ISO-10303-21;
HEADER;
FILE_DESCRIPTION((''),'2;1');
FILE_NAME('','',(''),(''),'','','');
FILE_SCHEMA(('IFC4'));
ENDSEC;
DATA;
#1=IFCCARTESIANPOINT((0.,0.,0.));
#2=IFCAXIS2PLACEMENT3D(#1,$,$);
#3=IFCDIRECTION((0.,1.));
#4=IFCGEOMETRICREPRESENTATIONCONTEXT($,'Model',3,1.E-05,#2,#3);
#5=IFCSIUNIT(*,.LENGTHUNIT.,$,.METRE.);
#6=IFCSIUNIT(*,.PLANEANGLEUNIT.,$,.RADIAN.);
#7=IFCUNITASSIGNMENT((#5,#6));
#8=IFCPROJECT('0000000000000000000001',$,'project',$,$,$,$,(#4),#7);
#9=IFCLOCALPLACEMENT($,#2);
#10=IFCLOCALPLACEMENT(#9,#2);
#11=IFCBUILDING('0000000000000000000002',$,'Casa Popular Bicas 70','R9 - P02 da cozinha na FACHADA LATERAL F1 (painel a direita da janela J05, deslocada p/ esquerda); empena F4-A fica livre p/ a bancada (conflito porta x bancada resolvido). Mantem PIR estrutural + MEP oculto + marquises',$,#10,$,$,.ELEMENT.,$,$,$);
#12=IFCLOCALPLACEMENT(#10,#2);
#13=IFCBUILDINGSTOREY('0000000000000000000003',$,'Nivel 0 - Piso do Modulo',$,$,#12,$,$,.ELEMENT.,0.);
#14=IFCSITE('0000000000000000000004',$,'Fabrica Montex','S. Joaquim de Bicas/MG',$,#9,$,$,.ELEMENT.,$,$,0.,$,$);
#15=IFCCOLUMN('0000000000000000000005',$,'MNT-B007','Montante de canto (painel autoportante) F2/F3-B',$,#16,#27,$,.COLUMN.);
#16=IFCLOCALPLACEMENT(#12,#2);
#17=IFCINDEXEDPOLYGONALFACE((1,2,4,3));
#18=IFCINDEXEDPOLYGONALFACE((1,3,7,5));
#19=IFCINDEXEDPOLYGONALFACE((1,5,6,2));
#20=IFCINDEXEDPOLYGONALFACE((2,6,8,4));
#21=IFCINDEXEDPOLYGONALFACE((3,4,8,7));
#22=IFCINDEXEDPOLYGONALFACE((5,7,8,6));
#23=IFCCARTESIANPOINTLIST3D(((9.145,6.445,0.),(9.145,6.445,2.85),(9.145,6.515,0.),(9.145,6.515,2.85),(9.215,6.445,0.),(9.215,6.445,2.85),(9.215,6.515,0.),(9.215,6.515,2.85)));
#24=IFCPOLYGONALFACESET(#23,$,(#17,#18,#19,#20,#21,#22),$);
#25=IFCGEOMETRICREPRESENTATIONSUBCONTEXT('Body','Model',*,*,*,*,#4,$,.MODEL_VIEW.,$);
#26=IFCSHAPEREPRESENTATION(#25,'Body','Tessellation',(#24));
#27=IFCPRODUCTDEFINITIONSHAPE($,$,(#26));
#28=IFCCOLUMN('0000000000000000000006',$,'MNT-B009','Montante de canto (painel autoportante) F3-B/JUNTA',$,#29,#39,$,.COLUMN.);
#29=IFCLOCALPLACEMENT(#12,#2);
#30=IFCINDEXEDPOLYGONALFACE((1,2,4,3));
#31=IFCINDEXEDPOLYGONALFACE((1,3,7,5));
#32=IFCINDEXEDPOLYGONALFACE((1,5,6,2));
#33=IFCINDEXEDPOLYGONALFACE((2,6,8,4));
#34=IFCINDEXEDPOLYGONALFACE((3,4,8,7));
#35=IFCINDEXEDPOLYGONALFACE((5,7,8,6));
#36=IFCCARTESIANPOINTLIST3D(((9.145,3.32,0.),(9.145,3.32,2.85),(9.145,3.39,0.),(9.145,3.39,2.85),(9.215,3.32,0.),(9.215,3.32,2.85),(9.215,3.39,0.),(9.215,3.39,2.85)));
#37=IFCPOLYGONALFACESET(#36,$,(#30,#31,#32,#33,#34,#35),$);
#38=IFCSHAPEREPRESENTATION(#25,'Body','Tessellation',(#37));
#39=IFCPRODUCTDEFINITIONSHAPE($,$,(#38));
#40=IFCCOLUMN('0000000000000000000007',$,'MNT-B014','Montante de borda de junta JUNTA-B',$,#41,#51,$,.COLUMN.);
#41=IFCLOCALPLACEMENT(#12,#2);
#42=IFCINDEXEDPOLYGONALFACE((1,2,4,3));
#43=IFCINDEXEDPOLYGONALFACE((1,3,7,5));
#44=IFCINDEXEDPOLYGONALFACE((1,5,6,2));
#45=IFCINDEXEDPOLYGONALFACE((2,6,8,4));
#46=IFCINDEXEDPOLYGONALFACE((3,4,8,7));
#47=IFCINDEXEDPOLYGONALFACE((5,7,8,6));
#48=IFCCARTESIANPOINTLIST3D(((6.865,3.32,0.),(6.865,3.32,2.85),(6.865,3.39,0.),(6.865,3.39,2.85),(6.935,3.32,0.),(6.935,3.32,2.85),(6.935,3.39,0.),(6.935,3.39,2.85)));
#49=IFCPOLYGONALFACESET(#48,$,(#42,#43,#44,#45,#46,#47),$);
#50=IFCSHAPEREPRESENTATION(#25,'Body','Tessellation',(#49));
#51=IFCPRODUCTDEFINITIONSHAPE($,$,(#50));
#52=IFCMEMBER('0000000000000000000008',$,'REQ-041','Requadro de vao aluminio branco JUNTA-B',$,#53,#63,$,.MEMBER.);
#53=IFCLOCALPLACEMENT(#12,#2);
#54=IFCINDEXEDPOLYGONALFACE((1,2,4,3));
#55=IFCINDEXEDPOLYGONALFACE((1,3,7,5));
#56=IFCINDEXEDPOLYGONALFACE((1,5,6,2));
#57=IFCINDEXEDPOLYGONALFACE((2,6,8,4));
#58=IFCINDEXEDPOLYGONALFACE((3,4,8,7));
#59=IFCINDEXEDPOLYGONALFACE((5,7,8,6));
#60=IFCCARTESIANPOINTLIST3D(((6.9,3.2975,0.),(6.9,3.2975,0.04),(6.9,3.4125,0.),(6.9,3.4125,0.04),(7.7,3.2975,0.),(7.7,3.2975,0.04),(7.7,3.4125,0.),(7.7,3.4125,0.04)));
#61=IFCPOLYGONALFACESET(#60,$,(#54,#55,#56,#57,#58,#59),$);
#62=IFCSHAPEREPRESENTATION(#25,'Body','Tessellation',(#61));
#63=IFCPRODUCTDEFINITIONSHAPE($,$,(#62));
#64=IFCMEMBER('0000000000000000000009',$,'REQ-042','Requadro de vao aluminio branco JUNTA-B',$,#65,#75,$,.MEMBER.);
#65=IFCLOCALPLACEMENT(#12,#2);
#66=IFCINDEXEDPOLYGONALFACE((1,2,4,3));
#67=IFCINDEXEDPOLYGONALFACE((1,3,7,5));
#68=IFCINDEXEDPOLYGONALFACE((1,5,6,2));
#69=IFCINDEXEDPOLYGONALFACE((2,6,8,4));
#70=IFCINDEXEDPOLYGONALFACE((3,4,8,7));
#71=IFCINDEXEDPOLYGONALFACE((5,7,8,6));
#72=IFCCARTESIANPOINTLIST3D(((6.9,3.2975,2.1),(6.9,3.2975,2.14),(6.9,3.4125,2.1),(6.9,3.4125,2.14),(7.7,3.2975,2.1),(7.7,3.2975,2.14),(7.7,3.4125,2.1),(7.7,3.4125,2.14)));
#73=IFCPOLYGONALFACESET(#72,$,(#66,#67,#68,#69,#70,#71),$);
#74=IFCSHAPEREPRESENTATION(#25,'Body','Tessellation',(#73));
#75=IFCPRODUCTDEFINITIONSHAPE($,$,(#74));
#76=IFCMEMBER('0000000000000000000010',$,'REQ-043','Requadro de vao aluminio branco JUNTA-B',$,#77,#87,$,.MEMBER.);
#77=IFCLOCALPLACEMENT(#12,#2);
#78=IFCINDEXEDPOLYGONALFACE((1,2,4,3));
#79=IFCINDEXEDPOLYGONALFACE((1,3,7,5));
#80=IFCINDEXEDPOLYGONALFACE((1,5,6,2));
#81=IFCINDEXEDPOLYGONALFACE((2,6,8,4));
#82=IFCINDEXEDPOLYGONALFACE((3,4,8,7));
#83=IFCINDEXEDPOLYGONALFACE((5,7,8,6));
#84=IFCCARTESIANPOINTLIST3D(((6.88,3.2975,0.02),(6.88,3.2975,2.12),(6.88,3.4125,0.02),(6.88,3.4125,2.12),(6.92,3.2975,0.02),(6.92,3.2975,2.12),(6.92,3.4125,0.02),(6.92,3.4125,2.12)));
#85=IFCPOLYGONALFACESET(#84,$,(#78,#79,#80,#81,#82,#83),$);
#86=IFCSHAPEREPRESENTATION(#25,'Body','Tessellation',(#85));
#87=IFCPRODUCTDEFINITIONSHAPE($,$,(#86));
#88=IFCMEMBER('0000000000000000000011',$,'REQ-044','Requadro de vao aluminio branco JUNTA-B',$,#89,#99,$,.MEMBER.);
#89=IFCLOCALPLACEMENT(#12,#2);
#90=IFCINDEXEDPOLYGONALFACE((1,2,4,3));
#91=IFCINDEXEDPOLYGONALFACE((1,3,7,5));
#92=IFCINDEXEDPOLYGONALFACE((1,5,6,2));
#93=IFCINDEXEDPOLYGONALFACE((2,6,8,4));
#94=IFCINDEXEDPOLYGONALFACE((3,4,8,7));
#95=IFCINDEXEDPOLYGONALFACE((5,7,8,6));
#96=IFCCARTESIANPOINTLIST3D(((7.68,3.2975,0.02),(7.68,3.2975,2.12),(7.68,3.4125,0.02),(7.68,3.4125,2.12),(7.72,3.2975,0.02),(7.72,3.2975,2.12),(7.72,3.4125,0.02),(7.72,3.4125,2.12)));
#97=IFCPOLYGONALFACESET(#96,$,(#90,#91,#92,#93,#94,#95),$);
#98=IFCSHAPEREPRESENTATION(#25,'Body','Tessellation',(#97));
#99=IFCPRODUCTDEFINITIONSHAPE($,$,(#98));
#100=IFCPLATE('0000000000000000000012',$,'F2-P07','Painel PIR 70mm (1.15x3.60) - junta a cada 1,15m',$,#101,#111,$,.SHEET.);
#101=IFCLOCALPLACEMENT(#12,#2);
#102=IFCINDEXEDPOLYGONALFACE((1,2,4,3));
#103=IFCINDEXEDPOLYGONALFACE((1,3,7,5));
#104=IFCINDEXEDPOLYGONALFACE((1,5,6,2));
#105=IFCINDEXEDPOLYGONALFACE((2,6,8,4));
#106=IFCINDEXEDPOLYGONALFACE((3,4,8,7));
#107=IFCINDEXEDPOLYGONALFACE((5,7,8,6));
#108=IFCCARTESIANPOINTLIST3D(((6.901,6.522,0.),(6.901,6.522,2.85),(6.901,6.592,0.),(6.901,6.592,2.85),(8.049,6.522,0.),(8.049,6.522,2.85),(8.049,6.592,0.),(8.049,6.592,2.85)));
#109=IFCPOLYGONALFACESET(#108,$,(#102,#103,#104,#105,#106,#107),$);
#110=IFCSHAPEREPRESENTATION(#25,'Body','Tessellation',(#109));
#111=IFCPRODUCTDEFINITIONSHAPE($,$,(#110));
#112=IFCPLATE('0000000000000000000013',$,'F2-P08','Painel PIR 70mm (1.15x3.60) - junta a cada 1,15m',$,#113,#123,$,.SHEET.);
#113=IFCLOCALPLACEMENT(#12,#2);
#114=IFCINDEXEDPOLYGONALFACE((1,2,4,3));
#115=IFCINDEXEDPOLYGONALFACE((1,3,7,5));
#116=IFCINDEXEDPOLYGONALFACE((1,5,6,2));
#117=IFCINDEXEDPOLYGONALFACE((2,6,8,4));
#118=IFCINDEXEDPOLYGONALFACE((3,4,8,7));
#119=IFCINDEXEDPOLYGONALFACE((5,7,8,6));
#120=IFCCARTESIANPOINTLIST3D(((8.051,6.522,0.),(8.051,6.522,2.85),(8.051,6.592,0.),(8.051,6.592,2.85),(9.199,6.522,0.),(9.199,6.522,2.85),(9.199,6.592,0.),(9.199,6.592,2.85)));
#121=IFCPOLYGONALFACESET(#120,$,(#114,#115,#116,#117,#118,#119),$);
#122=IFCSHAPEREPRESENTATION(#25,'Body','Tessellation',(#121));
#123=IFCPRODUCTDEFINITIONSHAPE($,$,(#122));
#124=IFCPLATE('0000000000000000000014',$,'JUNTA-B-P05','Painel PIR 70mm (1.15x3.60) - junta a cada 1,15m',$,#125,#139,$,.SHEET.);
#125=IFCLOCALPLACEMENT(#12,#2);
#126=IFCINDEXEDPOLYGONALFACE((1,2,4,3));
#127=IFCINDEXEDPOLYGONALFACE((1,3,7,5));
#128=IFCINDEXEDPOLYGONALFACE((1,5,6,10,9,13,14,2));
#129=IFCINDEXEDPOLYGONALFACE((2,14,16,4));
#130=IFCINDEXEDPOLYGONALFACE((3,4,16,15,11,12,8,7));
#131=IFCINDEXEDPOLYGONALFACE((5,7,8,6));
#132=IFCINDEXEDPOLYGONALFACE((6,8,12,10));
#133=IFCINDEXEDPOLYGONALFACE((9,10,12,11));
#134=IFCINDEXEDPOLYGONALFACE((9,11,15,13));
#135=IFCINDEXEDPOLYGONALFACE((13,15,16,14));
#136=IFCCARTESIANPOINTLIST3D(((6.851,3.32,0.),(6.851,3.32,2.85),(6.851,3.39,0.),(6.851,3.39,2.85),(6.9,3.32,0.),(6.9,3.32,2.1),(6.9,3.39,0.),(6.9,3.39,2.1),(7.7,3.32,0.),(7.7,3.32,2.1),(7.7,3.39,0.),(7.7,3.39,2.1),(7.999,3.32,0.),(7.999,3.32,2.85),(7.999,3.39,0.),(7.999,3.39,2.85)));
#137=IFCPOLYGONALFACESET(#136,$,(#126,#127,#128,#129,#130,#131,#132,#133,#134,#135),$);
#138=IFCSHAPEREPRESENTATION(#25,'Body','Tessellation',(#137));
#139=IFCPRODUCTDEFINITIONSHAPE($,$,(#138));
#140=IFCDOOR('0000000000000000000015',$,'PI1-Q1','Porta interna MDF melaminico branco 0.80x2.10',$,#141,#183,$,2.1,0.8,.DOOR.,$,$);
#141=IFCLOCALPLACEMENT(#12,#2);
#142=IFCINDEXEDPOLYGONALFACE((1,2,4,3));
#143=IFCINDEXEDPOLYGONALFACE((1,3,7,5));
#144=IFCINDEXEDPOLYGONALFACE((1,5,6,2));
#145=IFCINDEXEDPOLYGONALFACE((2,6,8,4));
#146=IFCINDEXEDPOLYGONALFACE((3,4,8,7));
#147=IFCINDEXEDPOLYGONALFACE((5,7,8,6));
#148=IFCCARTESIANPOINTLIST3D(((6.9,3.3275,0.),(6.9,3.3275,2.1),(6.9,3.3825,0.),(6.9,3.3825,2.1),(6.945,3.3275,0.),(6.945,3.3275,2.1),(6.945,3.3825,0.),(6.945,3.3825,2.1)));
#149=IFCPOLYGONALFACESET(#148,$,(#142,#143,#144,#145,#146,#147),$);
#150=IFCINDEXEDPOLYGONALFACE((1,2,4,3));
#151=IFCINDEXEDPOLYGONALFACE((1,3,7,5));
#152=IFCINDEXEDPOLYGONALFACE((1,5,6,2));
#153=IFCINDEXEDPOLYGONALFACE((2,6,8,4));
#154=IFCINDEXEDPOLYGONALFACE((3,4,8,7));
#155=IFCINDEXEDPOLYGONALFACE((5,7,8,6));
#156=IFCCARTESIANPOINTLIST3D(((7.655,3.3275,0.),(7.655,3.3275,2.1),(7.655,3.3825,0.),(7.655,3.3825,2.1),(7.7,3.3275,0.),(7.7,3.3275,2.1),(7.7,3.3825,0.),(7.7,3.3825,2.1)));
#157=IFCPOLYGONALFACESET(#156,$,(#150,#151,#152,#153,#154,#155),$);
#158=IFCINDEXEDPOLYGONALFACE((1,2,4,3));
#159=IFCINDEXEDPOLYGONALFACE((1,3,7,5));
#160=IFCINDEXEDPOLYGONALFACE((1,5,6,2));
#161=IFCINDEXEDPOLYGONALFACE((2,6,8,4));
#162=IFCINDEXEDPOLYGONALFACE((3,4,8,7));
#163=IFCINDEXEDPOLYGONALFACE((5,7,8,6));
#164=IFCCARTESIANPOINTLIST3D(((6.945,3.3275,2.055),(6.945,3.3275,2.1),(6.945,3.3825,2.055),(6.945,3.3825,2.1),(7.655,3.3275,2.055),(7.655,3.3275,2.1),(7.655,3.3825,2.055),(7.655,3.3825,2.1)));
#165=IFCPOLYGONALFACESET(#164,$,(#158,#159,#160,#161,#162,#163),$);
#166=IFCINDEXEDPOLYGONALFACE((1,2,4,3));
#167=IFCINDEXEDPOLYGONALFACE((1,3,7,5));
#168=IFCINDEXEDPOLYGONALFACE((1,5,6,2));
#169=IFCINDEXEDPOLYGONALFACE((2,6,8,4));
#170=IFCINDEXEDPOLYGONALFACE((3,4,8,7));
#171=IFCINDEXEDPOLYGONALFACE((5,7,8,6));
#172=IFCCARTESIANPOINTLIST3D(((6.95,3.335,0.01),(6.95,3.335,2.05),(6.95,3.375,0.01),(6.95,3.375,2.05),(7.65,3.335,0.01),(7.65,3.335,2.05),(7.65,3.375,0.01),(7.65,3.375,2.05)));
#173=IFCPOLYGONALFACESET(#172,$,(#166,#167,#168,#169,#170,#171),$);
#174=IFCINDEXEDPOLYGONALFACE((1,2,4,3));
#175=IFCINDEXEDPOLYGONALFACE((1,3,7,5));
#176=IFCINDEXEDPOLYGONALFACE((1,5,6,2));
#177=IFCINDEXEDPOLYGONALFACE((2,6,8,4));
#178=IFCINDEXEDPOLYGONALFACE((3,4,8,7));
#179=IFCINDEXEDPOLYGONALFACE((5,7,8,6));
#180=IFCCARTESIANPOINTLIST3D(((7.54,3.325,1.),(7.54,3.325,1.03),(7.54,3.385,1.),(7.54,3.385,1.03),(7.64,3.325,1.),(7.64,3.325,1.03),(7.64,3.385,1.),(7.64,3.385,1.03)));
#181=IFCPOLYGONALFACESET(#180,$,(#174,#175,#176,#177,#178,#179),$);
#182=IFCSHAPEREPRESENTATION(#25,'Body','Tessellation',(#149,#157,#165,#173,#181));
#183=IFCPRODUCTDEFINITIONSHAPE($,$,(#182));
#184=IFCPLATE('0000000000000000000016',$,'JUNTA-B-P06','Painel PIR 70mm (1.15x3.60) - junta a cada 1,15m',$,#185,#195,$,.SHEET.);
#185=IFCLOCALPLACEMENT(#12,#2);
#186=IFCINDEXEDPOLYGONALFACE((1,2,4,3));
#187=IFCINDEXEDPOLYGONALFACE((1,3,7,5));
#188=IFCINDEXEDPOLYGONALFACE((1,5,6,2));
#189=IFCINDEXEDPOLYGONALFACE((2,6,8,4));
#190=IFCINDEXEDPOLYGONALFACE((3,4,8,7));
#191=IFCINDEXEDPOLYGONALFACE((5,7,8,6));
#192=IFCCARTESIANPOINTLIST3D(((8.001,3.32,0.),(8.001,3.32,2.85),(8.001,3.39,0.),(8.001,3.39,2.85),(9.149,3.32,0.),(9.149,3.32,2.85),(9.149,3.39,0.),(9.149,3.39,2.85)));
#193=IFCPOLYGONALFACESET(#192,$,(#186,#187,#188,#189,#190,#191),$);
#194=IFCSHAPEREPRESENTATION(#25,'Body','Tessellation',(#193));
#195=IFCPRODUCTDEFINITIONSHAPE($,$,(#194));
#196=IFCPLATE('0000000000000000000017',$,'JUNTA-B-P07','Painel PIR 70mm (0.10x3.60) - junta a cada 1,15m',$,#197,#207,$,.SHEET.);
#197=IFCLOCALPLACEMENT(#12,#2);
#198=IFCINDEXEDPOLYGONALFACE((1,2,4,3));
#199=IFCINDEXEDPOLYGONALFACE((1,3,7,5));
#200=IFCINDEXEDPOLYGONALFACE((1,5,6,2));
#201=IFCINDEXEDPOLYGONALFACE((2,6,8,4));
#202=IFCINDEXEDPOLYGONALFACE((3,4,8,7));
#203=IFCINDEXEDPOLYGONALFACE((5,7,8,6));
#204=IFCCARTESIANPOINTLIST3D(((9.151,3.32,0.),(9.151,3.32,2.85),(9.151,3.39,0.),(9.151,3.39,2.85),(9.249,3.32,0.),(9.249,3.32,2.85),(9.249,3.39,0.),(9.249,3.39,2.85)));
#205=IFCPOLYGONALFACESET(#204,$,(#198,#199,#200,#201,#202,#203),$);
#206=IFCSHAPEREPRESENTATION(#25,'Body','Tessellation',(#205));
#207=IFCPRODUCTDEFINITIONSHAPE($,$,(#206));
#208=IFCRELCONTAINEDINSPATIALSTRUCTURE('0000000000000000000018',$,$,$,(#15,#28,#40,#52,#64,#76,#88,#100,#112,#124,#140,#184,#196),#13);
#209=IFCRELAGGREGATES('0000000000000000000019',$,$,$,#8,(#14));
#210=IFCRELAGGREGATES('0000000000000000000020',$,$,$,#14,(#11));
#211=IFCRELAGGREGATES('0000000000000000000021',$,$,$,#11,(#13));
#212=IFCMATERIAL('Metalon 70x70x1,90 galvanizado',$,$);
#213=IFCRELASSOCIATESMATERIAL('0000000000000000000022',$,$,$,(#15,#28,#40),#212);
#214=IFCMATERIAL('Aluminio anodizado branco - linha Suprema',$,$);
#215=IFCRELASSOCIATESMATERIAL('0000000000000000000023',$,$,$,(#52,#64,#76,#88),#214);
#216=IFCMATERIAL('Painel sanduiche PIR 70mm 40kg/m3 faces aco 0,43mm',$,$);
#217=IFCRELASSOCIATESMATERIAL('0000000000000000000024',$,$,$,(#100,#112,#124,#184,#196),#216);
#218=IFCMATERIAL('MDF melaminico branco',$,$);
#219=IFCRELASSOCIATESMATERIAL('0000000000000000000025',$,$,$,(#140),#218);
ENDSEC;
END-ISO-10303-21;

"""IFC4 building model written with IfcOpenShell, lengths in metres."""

from ifc_helpers import new_model, si_unit, direction, frame, frame_2d, origin, origin_2d, place, context, subcontext, project, spatial, rectangle, extrude, material, element, fill, save


model = new_model("IFC4")

# Units and contexts
model_context = context("Model", 3, precision=1e-05, world=origin(), true_north=direction((0.0, 1.0)))
body_context = subcontext(model_context, "Body", "Model", "MODEL_VIEW")
ifc_project = project(units=[si_unit("LENGTHUNIT", "METRE"), si_unit("PLANEANGLEUNIT", "RADIAN")], contexts=[model_context])

# Site, building, storey
site_placement = place(None, origin())
site = spatial("IfcSite", under=ifc_project, at=site_placement, Name="Fabrica Montex", Description="S. Joaquim de Bicas/MG", CompositionType="ELEMENT", RefElevation=0.0)
building_placement = place(site_placement, origin())
building = spatial("IfcBuilding", under=site, at=building_placement, Name="Casa Popular Bicas 70", Description="R9 - P02 da cozinha na FACHADA LATERAL F1 (painel a direita da janela J05, deslocada p/ esquerda); empena F4-A fica livre p/ a bancada (conflito porta x bancada resolvido). Mantem PIR estrutural + MEP oculto + marquises", CompositionType="ELEMENT")
storey_placement = place(building_placement, origin())
storey = spatial("IfcBuildingStorey", under=building, at=storey_placement, Name="Nivel 0 - Piso do Modulo", CompositionType="ELEMENT", Elevation=0.0)

# Columns
ifc_material_1 = material(Name="Metalon 70x70x1,90 galvanizado")
for number, where, name, description in (
    (1, (9.18, 6.48, 0.0), "MNT-B007", "Montante de canto (painel autoportante) F2/F3-B"),
    (2, (9.18, 3.355, 0.0), "MNT-B009", "Montante de canto (painel autoportante) F3-B/JUNTA"),
    (3, (6.9, 3.355, 0.0), "MNT-B014", "Montante de borda de junta JUNTA-B"),
):
    element("IfcColumn", number, at=place(storey_placement, frame(where)), inside=storey, material=ifc_material_1, Name=name, Description=description, PredefinedType="COLUMN", context=body_context, shape_type="SweptSolid", body=[
        extrude(rectangle(XDim=0.07, YDim=0.07, at=origin_2d()), origin(), (0.0, 0.0, 1.0), 2.85),
    ])

# Members
ifc_material_2 = material(Name="Aluminio anodizado branco - linha Suprema")
for number, where, z_axis, x_axis, name in (
    (4, (6.9, 3.355, 0.02), (1.0, 0.0, 0.0), (0.0, 0.0, 1.0), "REQ-041"),
    (5, (6.9, 3.355, 2.12), (1.0, 0.0, 0.0), (0.0, 0.0, 1.0), "REQ-042"),
):
    element("IfcMember", number, at=place(storey_placement, frame(where, z_axis=z_axis, x_axis=x_axis)), inside=storey, material=ifc_material_2, Name=name, Description="Requadro de vao aluminio branco JUNTA-B", PredefinedType="MEMBER", context=body_context, shape_type="SweptSolid", body=[
        extrude(rectangle(XDim=0.04, YDim=0.115, at=origin_2d()), origin(), (0.0, 0.0, 1.0), 0.8),
    ])
for number, where, z_axis, x_axis, name in (
    (6, (6.9, 3.355, 0.02), (0.0, 0.0, 1.0), (1.0, 0.0, 0.0), "REQ-043"),
    (7, (7.7, 3.355, 0.02), (0.0, 0.0, 1.0), (1.0, 0.0, 0.0), "REQ-044"),
):
    element("IfcMember", number, at=place(storey_placement, frame(where, z_axis=z_axis, x_axis=x_axis)), inside=storey, material=ifc_material_2, Name=name, Description="Requadro de vao aluminio branco JUNTA-B", PredefinedType="MEMBER", context=body_context, shape_type="SweptSolid", body=[
        extrude(rectangle(XDim=0.04, YDim=0.115, at=origin_2d()), origin(), (0.0, 0.0, 1.0), 2.1),
    ])

# Plates
ifc_material_3 = material(Name="Painel sanduiche PIR 70mm 40kg/m3 faces aco 0,43mm")
for number, where, x_axis, name in (
    (8, (6.901, 6.557, 0.0), (1.0, 0.0, 0.0), "F2-P07"),
    (9, (8.051, 6.557, 0.0), (1.0, 0.0, 0.0), "F2-P08"),
):
    element("IfcPlate", number, at=place(storey_placement, frame(where, x_axis=x_axis)), inside=storey, material=ifc_material_3, Name=name, Description="Painel PIR 70mm (1.15x3.60) - junta a cada 1,15m", PredefinedType="SHEET", context=body_context, shape_type="SweptSolid", body=[
        extrude(rectangle(XDim=1.148, YDim=0.07, at=frame_2d((0.574, 0.0))), origin(), (0.0, 0.0, 1.0), 2.85),
    ])

# Plate, opening, door
plate_1_placement = place(storey_placement, frame((6.851, 3.355, 0.0), x_axis=(1.0, 0.0, 0.0)))
plate_1 = element("IfcPlate", 10, at=plate_1_placement, inside=storey, material=ifc_material_3, Name="JUNTA-B-P05", Description="Painel PIR 70mm (1.15x3.60) - junta a cada 1,15m", PredefinedType="SHEET", context=body_context, shape_type="SweptSolid", body=[
    extrude(rectangle(XDim=1.148, YDim=0.07, at=frame_2d((0.574, 0.0))), origin(), (0.0, 0.0, 1.0), 2.85),
])
opening_placement = place(storey_placement, frame((7.3, 3.355, 0.0)))
opening = element("IfcOpeningElement", 11, at=opening_placement, cuts=plate_1, PredefinedType="OPENING", context=body_context, shape_type="SweptSolid", body=[
    extrude(rectangle(XDim=0.8, YDim=0.1, at=origin_2d()), origin(), (0.0, 0.0, 1.0), 2.1),
])
ifc_material_4 = material(Name="MDF melaminico branco")
door_placement = place(storey_placement, frame((6.9, 3.355, 0.0), x_axis=(1.0, 0.0, 0.0)))
door = element("IfcDoor", 12, at=door_placement, inside=storey, material=ifc_material_4, Name="PI1-Q1", Description="Porta interna MDF melaminico branco 0.80x2.10", OverallHeight=2.1, OverallWidth=0.8, PredefinedType="DOOR", context=body_context, shape_type="SweptSolid", body=[
    extrude(rectangle(XDim=0.045, YDim=0.055, at=frame_2d((0.0225, 0.0))), origin(), (0.0, 0.0, 1.0), 2.1),
    extrude(rectangle(XDim=0.045, YDim=0.055, at=frame_2d((0.7775, 0.0))), origin(), (0.0, 0.0, 1.0), 2.1),
    extrude(rectangle(XDim=0.71, YDim=0.055, at=frame_2d((0.4, 0.0))), frame((0.0, 0.0, 2.055)), (0.0, 0.0, 1.0), 0.045),
    extrude(rectangle(XDim=0.7, YDim=0.04, at=frame_2d((0.4, 0.0))), frame((0.0, 0.0, 0.01)), (0.0, 0.0, 1.0), 2.04),
    extrude(rectangle(XDim=0.1, YDim=0.06, at=frame_2d((0.69, 0.0))), frame((0.0, 0.0, 1.0)), (0.0, 0.0, 1.0), 0.03),
])
fill(opening, door)

# Plates
plate_2_placement = place(storey_placement, frame((8.001, 3.355, 0.0), x_axis=(1.0, 0.0, 0.0)))
element("IfcPlate", 13, at=plate_2_placement, inside=storey, material=ifc_material_3, Name="JUNTA-B-P06", Description="Painel PIR 70mm (1.15x3.60) - junta a cada 1,15m", PredefinedType="SHEET", context=body_context, shape_type="SweptSolid", body=[
    extrude(rectangle(XDim=1.148, YDim=0.07, at=frame_2d((0.574, 0.0))), origin(), (0.0, 0.0, 1.0), 2.85),
])
plate_3_placement = place(storey_placement, frame((9.151, 3.355, 0.0), x_axis=(1.0, 0.0, 0.0)))
element("IfcPlate", 14, at=plate_3_placement, inside=storey, material=ifc_material_3, Name="JUNTA-B-P07", Description="Painel PIR 70mm (0.10x3.60) - junta a cada 1,15m", PredefinedType="SHEET", context=body_context, shape_type="SweptSolid", body=[
    extrude(rectangle(XDim=0.098, YDim=0.07, at=frame_2d((0.049, 0.0))), origin(), (0.0, 0.0, 1.0), 2.85),
])

save(model, "model.ifc")
